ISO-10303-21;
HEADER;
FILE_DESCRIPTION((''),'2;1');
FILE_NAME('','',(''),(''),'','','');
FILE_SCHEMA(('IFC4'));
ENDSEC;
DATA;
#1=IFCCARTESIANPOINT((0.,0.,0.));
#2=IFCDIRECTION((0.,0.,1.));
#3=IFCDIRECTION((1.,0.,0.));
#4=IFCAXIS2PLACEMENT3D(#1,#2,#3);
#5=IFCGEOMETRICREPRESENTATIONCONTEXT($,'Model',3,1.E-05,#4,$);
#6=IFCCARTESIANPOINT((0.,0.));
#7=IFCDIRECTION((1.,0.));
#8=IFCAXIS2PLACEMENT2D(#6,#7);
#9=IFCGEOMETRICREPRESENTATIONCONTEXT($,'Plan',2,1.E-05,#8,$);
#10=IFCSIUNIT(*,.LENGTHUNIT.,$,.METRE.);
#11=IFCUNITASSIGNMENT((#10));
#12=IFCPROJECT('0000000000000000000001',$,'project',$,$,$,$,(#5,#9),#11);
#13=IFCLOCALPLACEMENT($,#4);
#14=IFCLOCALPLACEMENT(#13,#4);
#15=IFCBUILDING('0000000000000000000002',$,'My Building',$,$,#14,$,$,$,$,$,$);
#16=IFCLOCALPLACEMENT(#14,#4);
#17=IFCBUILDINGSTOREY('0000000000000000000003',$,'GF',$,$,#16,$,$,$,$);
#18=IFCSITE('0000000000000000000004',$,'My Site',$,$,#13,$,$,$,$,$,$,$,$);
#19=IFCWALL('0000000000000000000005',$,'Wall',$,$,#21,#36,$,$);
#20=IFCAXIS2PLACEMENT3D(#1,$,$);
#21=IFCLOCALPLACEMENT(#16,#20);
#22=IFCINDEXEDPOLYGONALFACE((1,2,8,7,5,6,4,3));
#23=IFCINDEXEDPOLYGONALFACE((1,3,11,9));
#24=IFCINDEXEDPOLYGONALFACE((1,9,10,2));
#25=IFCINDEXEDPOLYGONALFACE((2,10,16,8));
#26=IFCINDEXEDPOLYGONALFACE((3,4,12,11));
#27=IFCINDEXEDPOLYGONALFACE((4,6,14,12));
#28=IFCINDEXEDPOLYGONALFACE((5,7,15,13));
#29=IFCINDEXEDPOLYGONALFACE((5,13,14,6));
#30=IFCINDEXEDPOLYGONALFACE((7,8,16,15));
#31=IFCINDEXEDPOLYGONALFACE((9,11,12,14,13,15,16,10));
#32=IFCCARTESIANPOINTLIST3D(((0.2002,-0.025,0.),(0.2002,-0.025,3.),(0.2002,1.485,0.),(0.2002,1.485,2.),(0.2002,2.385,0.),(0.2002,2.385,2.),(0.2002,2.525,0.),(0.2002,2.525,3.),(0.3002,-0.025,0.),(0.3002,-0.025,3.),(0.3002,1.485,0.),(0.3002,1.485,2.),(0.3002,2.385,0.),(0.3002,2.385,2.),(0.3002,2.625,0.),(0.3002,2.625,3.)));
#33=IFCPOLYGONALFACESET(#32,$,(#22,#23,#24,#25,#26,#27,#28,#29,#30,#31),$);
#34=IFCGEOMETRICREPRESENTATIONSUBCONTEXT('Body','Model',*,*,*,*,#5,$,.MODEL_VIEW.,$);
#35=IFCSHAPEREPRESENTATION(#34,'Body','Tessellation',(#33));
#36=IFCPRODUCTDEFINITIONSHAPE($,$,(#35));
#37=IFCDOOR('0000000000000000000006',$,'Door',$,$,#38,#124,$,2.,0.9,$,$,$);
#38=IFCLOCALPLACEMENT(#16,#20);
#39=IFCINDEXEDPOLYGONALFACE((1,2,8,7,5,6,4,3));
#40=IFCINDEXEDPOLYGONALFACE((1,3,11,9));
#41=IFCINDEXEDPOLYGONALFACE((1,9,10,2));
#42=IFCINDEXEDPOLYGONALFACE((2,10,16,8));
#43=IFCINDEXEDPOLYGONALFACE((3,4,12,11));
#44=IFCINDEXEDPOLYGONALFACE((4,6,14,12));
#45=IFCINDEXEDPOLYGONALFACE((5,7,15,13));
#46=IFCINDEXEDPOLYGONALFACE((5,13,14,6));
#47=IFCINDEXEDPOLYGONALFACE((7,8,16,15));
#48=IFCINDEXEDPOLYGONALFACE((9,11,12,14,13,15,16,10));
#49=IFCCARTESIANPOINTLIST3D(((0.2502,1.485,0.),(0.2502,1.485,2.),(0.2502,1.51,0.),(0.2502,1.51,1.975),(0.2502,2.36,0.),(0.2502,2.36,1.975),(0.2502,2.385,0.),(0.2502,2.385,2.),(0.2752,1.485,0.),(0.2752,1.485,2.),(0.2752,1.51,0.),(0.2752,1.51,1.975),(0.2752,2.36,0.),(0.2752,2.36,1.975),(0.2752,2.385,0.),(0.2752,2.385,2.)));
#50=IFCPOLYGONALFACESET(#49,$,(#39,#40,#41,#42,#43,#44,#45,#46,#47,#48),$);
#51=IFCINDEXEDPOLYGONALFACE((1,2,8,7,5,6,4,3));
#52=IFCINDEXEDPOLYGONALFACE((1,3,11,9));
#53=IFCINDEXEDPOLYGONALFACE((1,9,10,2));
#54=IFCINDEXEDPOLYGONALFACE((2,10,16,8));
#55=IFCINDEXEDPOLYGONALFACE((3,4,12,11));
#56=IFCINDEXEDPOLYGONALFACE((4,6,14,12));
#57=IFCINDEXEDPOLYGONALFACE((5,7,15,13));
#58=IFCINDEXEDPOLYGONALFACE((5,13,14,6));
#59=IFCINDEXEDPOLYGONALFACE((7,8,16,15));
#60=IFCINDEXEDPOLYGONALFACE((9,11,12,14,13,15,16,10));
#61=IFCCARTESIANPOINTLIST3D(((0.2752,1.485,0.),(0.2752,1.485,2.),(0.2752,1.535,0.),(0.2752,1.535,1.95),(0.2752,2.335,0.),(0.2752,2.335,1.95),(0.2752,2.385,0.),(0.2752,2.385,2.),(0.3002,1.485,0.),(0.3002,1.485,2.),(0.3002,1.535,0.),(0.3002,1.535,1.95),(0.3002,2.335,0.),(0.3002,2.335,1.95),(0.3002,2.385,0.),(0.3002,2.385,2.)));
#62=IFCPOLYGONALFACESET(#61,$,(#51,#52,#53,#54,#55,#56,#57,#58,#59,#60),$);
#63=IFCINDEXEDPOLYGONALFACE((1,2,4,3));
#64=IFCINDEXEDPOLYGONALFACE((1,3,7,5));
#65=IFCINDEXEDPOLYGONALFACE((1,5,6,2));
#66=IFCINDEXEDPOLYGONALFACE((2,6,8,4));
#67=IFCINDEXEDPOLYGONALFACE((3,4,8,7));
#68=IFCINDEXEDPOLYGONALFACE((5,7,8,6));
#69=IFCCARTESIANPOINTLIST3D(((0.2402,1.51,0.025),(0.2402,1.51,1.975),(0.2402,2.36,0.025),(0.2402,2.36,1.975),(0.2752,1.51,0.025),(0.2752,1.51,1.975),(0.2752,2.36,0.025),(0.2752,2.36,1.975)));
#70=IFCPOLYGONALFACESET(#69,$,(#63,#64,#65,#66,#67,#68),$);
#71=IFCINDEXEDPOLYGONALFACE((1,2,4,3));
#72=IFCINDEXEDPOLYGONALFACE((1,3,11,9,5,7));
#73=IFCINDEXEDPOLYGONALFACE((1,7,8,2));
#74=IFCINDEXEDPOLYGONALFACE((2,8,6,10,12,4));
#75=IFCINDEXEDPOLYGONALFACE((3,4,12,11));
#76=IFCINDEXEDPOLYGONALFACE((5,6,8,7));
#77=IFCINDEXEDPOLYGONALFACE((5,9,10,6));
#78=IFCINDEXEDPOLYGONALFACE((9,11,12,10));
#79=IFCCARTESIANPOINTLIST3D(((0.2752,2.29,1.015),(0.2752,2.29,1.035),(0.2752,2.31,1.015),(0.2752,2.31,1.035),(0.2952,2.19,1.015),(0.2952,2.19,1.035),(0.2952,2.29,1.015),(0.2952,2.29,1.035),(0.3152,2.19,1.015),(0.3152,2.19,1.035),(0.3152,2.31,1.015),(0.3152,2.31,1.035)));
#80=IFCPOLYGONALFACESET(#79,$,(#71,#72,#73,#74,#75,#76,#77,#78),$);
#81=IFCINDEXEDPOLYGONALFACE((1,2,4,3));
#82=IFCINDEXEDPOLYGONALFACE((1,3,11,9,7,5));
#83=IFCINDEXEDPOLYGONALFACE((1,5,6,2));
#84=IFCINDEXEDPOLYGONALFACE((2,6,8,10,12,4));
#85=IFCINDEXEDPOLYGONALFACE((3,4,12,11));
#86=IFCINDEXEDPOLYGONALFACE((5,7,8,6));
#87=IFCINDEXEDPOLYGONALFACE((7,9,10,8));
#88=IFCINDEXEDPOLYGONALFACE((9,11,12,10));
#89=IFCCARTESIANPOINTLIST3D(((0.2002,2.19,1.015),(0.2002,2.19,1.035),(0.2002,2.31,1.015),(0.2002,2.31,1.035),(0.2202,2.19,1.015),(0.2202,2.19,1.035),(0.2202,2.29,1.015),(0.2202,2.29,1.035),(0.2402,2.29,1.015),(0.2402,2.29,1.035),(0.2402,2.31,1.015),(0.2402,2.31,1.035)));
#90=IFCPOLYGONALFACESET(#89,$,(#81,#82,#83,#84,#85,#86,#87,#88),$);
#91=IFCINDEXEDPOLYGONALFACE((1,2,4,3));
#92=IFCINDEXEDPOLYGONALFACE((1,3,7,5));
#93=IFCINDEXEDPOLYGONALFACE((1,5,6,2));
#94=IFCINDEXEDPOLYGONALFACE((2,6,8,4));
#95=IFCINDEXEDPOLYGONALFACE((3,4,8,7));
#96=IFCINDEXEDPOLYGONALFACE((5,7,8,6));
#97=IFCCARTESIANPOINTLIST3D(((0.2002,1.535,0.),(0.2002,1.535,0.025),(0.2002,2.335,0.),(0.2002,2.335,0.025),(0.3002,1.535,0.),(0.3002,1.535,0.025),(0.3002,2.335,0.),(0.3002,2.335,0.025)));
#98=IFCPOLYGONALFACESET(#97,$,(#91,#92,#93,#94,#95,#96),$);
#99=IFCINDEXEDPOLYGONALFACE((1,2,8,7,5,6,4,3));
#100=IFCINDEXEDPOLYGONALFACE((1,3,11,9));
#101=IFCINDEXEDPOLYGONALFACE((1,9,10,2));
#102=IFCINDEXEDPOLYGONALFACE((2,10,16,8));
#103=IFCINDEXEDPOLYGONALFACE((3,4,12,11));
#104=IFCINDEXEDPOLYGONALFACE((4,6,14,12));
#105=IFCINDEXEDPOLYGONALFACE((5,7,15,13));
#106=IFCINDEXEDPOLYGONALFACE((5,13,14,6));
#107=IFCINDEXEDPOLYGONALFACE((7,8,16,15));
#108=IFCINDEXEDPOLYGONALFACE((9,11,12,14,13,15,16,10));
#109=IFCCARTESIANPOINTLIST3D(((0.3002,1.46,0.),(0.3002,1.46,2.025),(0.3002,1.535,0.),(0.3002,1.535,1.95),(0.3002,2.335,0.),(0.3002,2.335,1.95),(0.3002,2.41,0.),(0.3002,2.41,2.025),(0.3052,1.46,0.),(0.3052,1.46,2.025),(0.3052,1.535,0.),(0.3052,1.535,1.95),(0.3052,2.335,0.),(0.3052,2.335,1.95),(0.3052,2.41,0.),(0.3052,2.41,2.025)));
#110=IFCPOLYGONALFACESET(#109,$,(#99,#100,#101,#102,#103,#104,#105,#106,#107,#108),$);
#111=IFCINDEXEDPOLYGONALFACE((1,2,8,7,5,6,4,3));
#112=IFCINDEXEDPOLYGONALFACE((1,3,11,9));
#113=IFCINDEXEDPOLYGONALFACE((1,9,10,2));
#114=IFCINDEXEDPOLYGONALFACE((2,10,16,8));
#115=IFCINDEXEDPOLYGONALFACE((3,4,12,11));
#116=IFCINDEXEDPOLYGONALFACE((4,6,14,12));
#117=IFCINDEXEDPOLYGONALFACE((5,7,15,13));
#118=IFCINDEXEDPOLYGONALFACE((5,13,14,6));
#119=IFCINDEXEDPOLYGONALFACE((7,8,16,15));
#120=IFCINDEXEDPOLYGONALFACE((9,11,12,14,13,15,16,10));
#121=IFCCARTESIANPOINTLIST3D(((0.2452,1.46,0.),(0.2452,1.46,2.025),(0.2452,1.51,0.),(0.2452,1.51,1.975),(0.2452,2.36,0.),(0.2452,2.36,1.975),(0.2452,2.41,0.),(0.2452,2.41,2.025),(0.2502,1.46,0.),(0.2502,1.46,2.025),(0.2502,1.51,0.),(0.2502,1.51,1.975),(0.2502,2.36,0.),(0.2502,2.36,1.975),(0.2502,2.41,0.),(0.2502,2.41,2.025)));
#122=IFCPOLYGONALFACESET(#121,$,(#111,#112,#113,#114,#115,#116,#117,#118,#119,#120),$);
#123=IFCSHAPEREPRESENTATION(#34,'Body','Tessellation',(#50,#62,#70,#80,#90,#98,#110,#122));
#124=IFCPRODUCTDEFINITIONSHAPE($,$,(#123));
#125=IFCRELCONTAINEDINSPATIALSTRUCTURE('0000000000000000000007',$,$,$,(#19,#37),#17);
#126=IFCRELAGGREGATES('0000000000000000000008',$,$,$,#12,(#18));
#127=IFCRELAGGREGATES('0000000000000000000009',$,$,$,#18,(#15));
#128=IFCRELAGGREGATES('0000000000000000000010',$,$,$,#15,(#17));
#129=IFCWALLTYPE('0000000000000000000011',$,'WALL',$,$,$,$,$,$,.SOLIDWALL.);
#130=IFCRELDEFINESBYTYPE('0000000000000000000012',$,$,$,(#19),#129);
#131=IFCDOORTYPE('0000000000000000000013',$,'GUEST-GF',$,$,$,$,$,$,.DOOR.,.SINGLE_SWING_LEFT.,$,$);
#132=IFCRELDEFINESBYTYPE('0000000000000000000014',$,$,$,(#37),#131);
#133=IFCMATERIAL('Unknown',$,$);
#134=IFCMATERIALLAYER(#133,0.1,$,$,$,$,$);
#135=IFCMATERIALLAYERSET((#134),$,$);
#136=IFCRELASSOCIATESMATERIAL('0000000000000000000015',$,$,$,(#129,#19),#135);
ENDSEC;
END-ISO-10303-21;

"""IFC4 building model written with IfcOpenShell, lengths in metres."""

from ifc_helpers import new_model, entity, si_unit, frame, origin_with_axes, origin_2d_with_axis, place, context, subcontext, project, spatial, line, indexed_curve, outline, extrude, shape, source, transform, mapped, material, layer, layer_set, layer_usage, type_object, type_shapes, element, fill, save


model = new_model("IFC4")

# Units and contexts
model_context = context("Model", 3, precision=1e-05, world=origin_with_axes())
plan_context = context("Plan", 2, precision=1e-05, world=origin_2d_with_axis())
body_context_1 = subcontext(model_context, "Body", "Model", "MODEL_VIEW")
body_context_2 = subcontext(plan_context, "Body", "Plan", "PLAN_VIEW")
ifc_project = project(units=[si_unit("LENGTHUNIT", "METRE")], contexts=[model_context, plan_context])

# Site, building, storey
site_placement = place(None, origin_with_axes())
site = spatial("IfcSite", under=ifc_project, at=site_placement, Name="My Site")
building_placement = place(site_placement, origin_with_axes())
building = spatial("IfcBuilding", under=site, at=building_placement, Name="My Building")
storey_placement = place(building_placement, origin_with_axes())
storey = spatial("IfcBuildingStorey", under=building, at=storey_placement, Name="GF")

# Shared definitions
ifc_material = material(Name="Unknown")

# Shared definitions
ifc_layer_1 = layer(ifc_material, 0.1)
ifc_layer_set_1 = layer_set([ifc_layer_1])
wall_type = type_object("IfcWallType", Name="WALL", PredefinedType="SOLIDWALL", material=ifc_layer_set_1)

# Wall, opening, door
ifc_layer_usage_1 = layer_usage(ifc_layer_set_1, "AXIS2", "POSITIVE", 0.0)
wall_1_placement = place(storey_placement, frame((0.3002, -0.025, 0.0), z_axis=(0.0, 0.0, 1.0), x_axis=(0.0, 1.0, 0.0)))
wall_1 = element("IfcWall", 1, at=wall_1_placement, inside=storey, type_object=wall_type, material=ifc_layer_usage_1, Name="Wall", context=body_context_1, shape_type="SweptSolid", body=[
    extrude(outline(indexed_curve([(0.0, 0.0), (0.0, 0.1), (2.55, 0.1), (2.65, 0.0)], segments=[line(1, 2, 3, 4, 1)])), origin_with_axes(), (0.0, 0.0, 1.0), 3.0),
])
shared_shape_1 = source(origin_with_axes(), body_context_1, "Body", "SweptSolid", [
    extrude(outline(indexed_curve([(0.0, 0.0), (0.9, 0.0), (0.9, 2.0), (0.0, 2.0)], segments=[line(1, 2, 3, 4, 1)])), frame((0.0, -0.6, 0.0), z_axis=(0.0, -1.0, 0.0), x_axis=(1.0, 0.0, 0.0)), (0.0, 0.0, -1.0), 1.2),
])
opening_1_placement = place(wall_1_placement, frame((1.51, 0.0, 0.0), z_axis=(0.0, 0.0, 1.0), x_axis=(1.0, 0.0, 0.0)))
opening_1 = element("IfcOpeningElement", 2, at=opening_1_placement, cuts=wall_1, PredefinedType="OPENING", context=body_context_1, shape_type="MappedRepresentation", body=[
    mapped(shared_shape_1, transform((0.0, 0.0, 0.0), x_axis=(1.0, 0.0, 0.0), y_axis=(0.0, 1.0, 0.0), z_axis=(0.0, 0.0, 1.0), scale=1.0)),
])
door_type_1 = type_object("IfcDoorType", Name="GUEST-GF", OperationType="SINGLE_SWING_LEFT", PredefinedType="DOOR")
shared_shape_2 = source(origin_with_axes(), body_context_1, "Body", "SweptSolid", [
    extrude(outline(indexed_curve([(0.0, 0.0), (0.0, 2.0), (0.9, 2.0), (0.9, 0.0), (0.875, 0.0), (0.875, 1.975), (0.025, 1.975), (0.025, 0.0)], segments=[line(1, 2, 3, 4, 5, 6, 7, 8, 1)])), frame((0.0, 0.025, 0.0), z_axis=(0.0, -1.0, 0.0), x_axis=(1.0, 0.0, 0.0)), (0.0, 0.0, -1.0), 0.025),
    extrude(outline(indexed_curve([(0.0, 0.0), (0.0, 2.0), (0.9, 2.0), (0.9, 0.0), (0.85, 0.0), (0.85, 1.95), (0.05, 1.95), (0.05, 0.0)], segments=[line(1, 2, 3, 4, 5, 6, 7, 8, 1)])), frame((0.0, 0.0, 0.0), z_axis=(0.0, -1.0, 0.0), x_axis=(1.0, 0.0, 0.0)), (0.0, 0.0, -1.0), 0.025),
    extrude(outline(indexed_curve([(0.0, 0.0), (0.85, 0.0), (0.85, 0.035), (0.0, 0.035)], segments=[line(1, 2, 3, 4, 1)])), frame((0.025, 0.025, 0.025), z_axis=(0.0, 0.0, 1.0), x_axis=(1.0, 0.0, 0.0)), (0.0, 0.0, 1.0), 1.95),
    extrude(outline(indexed_curve([(0.0, 0.0), (0.0, -0.04), (-0.12, -0.04), (-0.12, -0.02), (-0.02, -0.02), (-0.02, 0.0)], segments=[line(1, 2, 3, 4, 5, 6, 1)])), frame((0.825, 0.025, 1.015), z_axis=(0.0, 0.0, 1.0), x_axis=(1.0, 0.0, 0.0)), (0.0, 0.0, 1.0), 0.02),
    extrude(outline(indexed_curve([(0.0, 0.0), (0.0, 0.04), (-0.12, 0.04), (-0.12, 0.02), (-0.02, 0.02), (-0.02, 0.0)], segments=[line(1, 2, 3, 4, 5, 6, 1)])), frame((0.825, 0.06, 1.015), z_axis=(0.0, 0.0, 1.0), x_axis=(1.0, 0.0, 0.0)), (0.0, 0.0, 1.0), 0.02),
    extrude(outline(indexed_curve([(0.0, 0.0), (0.8, 0.0), (0.8, 0.1), (0.0, 0.1)], segments=[line(1, 2, 3, 4, 1)])), frame((0.05, 0.0, 0.0), z_axis=(0.0, 0.0, 1.0), x_axis=(1.0, 0.0, 0.0)), (0.0, 0.0, 1.0), 0.025),
    extrude(outline(indexed_curve([(0.0, 0.0), (0.0, 2.025), (0.95, 2.025), (0.95, 0.0), (0.875, 0.0), (0.875, 1.95), (0.075, 1.95), (0.075, 0.0)], segments=[line(1, 2, 3, 4, 5, 6, 7, 8, 1)])), frame((-0.025, -0.005, 0.0), z_axis=(0.0, -1.0, 0.0), x_axis=(1.0, 0.0, 0.0)), (0.0, 0.0, -1.0), 0.005),
    extrude(outline(indexed_curve([(0.0, 0.0), (0.0, 2.025), (0.95, 2.025), (0.95, 0.0), (0.9, 0.0), (0.9, 1.975), (0.05, 1.975), (0.05, 0.0)], segments=[line(1, 2, 3, 4, 5, 6, 7, 8, 1)])), frame((-0.025, 0.05, 0.0), z_axis=(0.0, -1.0, 0.0), x_axis=(1.0, 0.0, 0.0)), (0.0, 0.0, -1.0), 0.005),
])
shared_shape_3 = source(origin_with_axes(), body_context_2, "Body", "Curve2D", [
    entity("IfcIndexedPolyCurve", entity("IfcCartesianPointList2D", [[0.0, 0.0], [0.0, 0.05], [0.025, 0.05], [0.025, 0.025], [0.05, 0.025], [0.05, 0.0]]), [entity("IfcLineIndex", [1, 2, 3, 4, 5, 6, 1])]),
    entity("IfcIndexedPolyCurve", entity("IfcCartesianPointList2D", [[0.9, 0.0], [0.9, 0.05], [0.875, 0.05], [0.875, 0.025], [0.85, 0.025], [0.85, 0.0]]), [entity("IfcLineIndex", [1, 2, 3, 4, 5, 6, 1])]),
    entity("IfcTrimmedCurve", entity("IfcEllipse", entity("IfcAxis2Placement2D", entity("IfcCartesianPoint", [0.06, 0.05]), entity("IfcDirection", [1.0, 0.0])), 0.815, 0.85), [entity("IfcCartesianPoint", [0.875, 0.05])], [entity("IfcCartesianPoint", [0.06, 0.9])], True, "CARTESIAN"),
    entity("IfcIndexedPolyCurve", entity("IfcCartesianPointList2D", [[0.025, 0.05], [0.06, 0.05], [0.06, 0.9], [0.025, 0.9]]), [entity("IfcLineIndex", [1, 2, 3, 4, 1])]),
])
type_shapes(door_type_1, [shared_shape_2, shared_shape_3])
door_1_placement = place(opening_1_placement, frame((0.0, 0.0, 0.0), z_axis=(0.0, 0.0, 1.0), x_axis=(1.0, 0.0, 0.0)))
door_1 = element("IfcDoor", 3, at=door_1_placement, inside=storey, type_object=door_type_1, Name="Door", OverallHeight=2.0, OverallWidth=0.9, shapes=[
    shape(body_context_1, "Body", "MappedRepresentation", [mapped(shared_shape_2, transform((0.0, 0.0, 0.0), x_axis=(1.0, 0.0, 0.0), y_axis=(0.0, 1.0, 0.0), z_axis=(0.0, 0.0, 1.0), scale=1.0))]),
    shape(body_context_2, "Body", "MappedRepresentation", [mapped(shared_shape_3, transform((0.0, 0.0, 0.0), x_axis=(1.0, 0.0, 0.0), y_axis=(0.0, 1.0, 0.0), z_axis=(0.0, 0.0, 1.0), scale=1.0))]),
])
fill(opening_1, door_1)

save(model, "model.ifc")
